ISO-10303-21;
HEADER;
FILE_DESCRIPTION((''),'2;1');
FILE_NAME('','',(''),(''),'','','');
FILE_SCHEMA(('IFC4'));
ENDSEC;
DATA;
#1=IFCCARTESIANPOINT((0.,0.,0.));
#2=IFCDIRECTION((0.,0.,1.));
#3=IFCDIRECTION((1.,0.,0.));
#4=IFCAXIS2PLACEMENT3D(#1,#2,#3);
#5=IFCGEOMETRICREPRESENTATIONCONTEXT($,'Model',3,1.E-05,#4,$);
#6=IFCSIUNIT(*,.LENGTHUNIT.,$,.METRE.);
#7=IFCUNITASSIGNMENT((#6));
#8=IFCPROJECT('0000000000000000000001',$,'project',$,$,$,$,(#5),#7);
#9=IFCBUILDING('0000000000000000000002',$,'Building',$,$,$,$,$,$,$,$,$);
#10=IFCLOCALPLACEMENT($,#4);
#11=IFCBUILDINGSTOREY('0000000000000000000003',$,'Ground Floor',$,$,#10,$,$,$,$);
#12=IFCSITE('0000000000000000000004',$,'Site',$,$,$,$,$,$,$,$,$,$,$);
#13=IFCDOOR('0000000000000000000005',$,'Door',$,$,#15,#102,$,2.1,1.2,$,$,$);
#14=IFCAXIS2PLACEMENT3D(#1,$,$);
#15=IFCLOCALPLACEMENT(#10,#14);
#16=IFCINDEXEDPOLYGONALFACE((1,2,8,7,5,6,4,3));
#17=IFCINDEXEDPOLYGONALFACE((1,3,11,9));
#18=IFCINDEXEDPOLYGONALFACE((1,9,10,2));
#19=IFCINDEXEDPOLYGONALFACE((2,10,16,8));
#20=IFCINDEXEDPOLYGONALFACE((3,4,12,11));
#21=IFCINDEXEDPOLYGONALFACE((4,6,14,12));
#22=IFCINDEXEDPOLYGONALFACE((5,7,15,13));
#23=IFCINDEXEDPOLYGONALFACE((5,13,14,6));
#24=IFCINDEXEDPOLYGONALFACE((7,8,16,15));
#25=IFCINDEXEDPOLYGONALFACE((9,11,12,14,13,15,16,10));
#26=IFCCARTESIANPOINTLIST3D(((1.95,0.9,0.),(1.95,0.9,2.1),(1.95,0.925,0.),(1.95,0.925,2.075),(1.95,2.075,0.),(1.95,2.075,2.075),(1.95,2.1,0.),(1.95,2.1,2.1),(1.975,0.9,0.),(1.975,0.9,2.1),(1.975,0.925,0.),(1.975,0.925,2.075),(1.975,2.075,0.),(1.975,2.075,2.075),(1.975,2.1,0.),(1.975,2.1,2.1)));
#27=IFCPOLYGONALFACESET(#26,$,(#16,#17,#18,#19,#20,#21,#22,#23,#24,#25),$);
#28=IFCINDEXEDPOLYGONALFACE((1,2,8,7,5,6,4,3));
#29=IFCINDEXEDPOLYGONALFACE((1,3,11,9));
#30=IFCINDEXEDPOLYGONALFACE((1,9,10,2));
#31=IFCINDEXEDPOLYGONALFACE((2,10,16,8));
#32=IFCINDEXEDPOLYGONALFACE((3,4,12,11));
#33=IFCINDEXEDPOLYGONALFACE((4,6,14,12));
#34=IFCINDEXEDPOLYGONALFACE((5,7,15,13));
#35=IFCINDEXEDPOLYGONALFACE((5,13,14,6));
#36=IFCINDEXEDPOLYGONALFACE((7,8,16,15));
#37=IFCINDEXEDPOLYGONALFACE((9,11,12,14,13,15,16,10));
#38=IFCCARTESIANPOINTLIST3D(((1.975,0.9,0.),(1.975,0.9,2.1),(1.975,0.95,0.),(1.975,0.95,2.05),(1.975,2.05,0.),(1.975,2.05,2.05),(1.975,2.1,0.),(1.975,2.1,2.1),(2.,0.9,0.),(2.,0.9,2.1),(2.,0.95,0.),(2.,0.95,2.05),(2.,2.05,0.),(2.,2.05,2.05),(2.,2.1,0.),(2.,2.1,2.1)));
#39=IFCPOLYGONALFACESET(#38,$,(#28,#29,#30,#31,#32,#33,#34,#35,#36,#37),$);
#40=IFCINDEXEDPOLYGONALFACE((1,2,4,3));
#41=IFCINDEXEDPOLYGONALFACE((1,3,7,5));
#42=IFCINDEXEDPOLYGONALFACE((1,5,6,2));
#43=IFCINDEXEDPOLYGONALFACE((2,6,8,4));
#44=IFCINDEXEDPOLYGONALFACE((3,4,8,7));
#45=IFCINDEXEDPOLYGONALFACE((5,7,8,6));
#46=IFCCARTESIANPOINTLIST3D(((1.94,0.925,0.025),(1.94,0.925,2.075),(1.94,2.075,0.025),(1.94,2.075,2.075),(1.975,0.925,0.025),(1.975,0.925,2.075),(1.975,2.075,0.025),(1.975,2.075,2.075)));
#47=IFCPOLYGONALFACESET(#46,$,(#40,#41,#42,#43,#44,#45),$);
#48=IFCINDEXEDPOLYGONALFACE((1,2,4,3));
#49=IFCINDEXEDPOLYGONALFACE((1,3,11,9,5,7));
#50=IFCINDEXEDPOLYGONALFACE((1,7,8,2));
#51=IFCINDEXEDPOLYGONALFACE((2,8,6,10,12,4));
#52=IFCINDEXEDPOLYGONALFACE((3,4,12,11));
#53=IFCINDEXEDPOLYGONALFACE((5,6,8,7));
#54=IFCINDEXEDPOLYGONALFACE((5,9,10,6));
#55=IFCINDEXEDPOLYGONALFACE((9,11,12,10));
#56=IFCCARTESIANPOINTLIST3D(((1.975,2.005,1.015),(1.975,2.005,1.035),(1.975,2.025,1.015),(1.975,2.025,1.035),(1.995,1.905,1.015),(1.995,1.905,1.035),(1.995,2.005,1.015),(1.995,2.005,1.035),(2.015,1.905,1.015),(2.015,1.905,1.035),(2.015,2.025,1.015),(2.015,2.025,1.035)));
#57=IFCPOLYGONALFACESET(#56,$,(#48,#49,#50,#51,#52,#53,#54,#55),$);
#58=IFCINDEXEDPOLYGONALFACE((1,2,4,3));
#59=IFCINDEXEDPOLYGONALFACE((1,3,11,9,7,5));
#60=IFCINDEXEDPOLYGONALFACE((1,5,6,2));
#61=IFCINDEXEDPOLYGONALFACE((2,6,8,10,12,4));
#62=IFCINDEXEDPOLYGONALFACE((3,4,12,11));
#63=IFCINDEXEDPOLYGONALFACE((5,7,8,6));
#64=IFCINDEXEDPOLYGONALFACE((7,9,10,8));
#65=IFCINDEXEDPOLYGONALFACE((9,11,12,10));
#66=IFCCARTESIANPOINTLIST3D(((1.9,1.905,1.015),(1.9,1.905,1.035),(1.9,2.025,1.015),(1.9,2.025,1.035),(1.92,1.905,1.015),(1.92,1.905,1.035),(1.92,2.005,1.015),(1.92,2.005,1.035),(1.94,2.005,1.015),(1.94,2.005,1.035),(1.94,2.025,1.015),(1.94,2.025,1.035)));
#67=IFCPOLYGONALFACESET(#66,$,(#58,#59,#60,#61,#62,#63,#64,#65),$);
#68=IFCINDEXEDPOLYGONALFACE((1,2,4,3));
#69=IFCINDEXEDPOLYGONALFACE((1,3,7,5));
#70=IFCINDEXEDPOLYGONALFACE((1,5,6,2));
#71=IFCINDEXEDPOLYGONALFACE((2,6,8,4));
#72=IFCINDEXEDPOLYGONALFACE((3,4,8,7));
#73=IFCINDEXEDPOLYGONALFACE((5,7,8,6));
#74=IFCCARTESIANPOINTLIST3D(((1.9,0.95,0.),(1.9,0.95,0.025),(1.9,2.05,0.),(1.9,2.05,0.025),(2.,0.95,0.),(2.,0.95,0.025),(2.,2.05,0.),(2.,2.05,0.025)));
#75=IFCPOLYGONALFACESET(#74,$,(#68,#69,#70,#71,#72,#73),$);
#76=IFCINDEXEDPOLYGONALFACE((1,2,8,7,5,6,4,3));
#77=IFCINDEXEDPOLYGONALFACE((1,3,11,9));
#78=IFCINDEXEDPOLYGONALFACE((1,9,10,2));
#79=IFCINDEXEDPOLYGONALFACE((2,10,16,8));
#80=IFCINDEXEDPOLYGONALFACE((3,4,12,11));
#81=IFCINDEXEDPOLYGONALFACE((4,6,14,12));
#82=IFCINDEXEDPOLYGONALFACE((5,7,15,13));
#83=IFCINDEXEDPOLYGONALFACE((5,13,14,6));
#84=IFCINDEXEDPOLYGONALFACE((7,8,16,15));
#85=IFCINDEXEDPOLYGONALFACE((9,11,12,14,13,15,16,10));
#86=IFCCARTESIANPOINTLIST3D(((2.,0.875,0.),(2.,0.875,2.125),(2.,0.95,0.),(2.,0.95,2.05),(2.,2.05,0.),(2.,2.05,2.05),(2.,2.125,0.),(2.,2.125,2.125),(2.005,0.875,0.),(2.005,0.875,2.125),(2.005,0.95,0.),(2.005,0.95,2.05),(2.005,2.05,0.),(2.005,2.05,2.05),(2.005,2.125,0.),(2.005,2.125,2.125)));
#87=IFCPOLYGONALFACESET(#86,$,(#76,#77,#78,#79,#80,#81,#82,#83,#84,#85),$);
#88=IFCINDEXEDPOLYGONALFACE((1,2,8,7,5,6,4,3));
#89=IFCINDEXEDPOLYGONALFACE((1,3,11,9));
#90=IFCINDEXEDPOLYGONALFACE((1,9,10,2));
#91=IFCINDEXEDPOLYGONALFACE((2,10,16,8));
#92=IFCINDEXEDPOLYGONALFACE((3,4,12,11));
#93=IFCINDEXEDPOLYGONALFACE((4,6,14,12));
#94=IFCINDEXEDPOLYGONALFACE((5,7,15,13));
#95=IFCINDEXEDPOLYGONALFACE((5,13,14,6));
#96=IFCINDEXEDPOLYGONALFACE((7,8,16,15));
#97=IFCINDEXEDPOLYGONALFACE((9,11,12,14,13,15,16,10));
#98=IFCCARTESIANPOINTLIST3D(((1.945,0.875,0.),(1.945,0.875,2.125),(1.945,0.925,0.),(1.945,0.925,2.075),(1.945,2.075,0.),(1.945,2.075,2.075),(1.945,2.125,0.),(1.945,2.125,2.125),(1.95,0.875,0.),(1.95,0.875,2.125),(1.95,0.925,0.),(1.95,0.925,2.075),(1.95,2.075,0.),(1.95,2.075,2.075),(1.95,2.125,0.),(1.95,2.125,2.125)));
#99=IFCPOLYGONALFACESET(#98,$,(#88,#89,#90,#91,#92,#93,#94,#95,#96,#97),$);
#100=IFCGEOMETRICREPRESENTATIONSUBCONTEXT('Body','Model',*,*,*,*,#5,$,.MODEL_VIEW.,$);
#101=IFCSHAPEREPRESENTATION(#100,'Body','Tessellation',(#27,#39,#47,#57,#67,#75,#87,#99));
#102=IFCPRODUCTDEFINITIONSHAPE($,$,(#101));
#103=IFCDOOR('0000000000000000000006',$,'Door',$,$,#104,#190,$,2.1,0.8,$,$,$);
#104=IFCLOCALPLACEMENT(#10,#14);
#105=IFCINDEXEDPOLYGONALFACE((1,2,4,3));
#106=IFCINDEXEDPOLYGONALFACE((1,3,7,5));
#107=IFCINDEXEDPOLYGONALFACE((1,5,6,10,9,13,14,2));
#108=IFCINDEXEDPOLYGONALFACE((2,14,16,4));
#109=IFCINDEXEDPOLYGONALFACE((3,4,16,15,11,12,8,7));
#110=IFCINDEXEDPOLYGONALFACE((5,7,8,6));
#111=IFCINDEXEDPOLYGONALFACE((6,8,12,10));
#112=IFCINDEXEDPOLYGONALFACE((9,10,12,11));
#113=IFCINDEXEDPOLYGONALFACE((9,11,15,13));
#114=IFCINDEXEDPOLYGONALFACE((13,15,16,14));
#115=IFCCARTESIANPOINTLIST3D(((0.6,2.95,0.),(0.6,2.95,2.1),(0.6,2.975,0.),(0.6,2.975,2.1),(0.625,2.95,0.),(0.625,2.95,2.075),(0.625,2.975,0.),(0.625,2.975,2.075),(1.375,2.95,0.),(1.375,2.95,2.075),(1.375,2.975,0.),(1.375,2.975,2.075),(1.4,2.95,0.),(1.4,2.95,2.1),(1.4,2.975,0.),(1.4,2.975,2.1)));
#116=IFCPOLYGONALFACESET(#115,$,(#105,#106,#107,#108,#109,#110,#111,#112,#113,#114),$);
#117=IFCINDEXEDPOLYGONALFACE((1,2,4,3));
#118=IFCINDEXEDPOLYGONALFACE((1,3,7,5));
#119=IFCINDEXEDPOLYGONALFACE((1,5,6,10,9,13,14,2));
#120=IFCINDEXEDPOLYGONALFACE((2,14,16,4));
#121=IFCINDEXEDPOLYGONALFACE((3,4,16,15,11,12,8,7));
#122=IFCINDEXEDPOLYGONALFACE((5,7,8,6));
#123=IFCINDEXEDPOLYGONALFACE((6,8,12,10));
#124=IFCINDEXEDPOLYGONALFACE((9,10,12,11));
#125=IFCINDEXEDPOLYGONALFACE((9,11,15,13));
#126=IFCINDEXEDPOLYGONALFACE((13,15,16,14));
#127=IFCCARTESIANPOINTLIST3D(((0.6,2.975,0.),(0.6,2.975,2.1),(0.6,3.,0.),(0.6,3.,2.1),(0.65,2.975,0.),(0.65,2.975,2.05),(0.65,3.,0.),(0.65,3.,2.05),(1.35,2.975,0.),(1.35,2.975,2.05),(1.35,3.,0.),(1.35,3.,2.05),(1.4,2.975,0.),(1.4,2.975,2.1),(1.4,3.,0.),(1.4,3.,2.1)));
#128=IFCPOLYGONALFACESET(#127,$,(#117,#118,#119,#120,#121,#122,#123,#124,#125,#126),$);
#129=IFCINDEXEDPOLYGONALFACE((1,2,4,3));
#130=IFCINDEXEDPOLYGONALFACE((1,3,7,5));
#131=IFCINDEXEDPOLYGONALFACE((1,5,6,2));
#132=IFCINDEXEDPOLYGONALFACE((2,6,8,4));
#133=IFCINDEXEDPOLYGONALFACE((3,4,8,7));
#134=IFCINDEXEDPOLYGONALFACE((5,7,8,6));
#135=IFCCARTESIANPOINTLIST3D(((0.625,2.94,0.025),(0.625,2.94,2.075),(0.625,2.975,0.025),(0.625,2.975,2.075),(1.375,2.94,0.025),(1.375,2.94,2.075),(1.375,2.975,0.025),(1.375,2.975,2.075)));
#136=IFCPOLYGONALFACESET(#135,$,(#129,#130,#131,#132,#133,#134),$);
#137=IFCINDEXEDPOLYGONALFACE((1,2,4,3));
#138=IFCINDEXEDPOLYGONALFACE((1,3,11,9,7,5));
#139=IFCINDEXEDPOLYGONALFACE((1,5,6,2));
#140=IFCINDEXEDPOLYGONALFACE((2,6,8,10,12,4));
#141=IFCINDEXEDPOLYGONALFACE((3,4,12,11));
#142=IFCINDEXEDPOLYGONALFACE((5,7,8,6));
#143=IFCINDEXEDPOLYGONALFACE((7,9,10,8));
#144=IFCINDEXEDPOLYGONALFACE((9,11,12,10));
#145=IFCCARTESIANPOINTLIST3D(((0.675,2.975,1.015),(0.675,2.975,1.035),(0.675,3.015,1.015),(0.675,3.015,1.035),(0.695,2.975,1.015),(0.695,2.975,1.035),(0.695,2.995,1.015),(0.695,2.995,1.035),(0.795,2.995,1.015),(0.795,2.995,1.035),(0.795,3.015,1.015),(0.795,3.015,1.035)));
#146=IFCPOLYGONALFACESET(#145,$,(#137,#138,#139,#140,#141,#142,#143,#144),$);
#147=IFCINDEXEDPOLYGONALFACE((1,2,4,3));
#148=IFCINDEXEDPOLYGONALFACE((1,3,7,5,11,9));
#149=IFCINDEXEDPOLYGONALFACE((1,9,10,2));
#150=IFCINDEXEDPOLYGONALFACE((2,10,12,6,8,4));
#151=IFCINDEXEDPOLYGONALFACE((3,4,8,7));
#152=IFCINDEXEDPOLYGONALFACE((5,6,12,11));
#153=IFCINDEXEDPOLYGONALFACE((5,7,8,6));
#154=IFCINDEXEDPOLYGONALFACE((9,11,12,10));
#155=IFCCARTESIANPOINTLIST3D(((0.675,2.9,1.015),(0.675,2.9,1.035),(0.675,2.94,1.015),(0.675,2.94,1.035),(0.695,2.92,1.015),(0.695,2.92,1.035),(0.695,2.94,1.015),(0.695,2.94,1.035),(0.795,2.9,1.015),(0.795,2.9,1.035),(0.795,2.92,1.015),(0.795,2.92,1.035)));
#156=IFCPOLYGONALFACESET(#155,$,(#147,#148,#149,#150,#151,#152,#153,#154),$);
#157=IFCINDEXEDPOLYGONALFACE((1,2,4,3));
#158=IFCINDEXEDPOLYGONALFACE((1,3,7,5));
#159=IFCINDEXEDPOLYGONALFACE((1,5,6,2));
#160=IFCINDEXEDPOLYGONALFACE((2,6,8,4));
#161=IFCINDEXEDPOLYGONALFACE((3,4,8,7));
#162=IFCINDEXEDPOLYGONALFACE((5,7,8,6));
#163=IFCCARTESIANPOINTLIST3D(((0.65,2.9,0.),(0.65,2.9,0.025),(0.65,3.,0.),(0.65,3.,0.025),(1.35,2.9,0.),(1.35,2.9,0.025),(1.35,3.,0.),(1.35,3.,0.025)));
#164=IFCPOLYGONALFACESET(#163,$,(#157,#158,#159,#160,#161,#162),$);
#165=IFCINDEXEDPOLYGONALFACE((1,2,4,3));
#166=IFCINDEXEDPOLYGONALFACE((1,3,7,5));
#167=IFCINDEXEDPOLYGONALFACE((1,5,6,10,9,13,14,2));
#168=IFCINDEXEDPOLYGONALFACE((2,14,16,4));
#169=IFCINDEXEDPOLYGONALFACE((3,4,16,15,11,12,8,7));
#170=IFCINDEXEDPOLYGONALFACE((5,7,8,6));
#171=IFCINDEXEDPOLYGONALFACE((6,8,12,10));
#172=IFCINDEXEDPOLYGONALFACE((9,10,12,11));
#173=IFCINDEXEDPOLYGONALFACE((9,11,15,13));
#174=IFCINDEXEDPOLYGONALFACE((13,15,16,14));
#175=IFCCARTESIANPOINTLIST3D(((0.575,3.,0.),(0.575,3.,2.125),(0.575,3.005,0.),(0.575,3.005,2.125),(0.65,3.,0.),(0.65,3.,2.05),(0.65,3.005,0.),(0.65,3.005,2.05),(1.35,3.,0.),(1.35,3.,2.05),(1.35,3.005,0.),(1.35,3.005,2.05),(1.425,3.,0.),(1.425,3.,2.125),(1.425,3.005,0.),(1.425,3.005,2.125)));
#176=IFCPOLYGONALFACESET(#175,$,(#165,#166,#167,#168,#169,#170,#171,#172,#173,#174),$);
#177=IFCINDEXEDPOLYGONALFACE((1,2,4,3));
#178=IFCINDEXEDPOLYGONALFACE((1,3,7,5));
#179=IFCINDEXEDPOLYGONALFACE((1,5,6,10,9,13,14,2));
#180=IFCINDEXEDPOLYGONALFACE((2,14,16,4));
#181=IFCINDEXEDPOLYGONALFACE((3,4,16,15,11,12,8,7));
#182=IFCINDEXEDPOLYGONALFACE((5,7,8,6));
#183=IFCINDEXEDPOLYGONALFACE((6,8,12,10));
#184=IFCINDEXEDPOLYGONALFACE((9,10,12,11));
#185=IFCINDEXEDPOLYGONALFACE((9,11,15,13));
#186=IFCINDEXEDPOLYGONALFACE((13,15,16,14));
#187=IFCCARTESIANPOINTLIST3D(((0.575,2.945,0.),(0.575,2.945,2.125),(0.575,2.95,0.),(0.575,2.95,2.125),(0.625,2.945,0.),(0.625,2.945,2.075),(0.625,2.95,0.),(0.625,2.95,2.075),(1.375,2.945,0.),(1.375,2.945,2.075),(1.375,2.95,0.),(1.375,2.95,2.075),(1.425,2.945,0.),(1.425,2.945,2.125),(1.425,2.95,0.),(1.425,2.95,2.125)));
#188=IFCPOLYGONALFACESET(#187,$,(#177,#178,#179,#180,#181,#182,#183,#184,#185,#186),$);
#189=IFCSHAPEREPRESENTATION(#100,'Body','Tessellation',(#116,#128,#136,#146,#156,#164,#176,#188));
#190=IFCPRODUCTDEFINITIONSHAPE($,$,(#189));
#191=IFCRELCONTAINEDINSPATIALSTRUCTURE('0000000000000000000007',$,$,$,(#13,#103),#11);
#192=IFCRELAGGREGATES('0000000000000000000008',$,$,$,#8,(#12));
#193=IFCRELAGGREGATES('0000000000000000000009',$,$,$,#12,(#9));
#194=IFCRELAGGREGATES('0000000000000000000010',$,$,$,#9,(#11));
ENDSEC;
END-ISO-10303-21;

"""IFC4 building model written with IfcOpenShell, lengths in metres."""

from ifc_helpers import new_model, si_unit, frame, origin_with_axes, place, context, subcontext, project, spatial, line, indexed_curve, outline, extrude, element, save


model = new_model("IFC4")

# Units and contexts
model_context = context("Model", 3, precision=1e-05, world=origin_with_axes())
body_context = subcontext(model_context, "Body", "Model", "MODEL_VIEW")
ifc_project = project(units=[si_unit("LENGTHUNIT", "METRE")], contexts=[model_context])

# Site, building, storey
site = spatial("IfcSite", under=ifc_project, Name="Site")
building = spatial("IfcBuilding", under=site, Name="Building")
storey_placement = place(None, origin_with_axes())
storey = spatial("IfcBuildingStorey", under=building, at=storey_placement, Name="Ground Floor")

# Doors
door_1_placement = place(storey_placement, frame((2.0, 0.9, 0.0), z_axis=(0.0, 0.0, 1.0), x_axis=(0.0, 1.0, 0.0)))
element("IfcDoor", 1, at=door_1_placement, inside=storey, Name="Door", OverallHeight=2.1, OverallWidth=1.2, context=body_context, shape_type="SweptSolid", body=[
    extrude(outline(indexed_curve([(0.0, 0.0), (0.0, 2.1), (1.2, 2.1), (1.2, 0.0), (1.175, 0.0), (1.175, 2.075), (0.025, 2.075), (0.025, 0.0)], segments=[line(1, 2, 3, 4, 5, 6, 7, 8, 1)])), frame((0.0, 0.025, 0.0), z_axis=(0.0, -1.0, 0.0), x_axis=(1.0, 0.0, 0.0)), (0.0, 0.0, -1.0), 0.025),
    extrude(outline(indexed_curve([(0.0, 0.0), (0.0, 2.1), (1.2, 2.1), (1.2, 0.0), (1.15, 0.0), (1.15, 2.05), (0.05, 2.05), (0.05, 0.0)], segments=[line(1, 2, 3, 4, 5, 6, 7, 8, 1)])), frame((0.0, 0.0, 0.0), z_axis=(0.0, -1.0, 0.0), x_axis=(1.0, 0.0, 0.0)), (0.0, 0.0, -1.0), 0.025),
    extrude(outline(indexed_curve([(0.0, 0.0), (1.15, 0.0), (1.15, 0.035), (0.0, 0.035)], segments=[line(1, 2, 3, 4, 1)])), frame((0.025, 0.025, 0.025), z_axis=(0.0, 0.0, 1.0), x_axis=(1.0, 0.0, 0.0)), (0.0, 0.0, 1.0), 2.05),
    extrude(outline(indexed_curve([(0.0, 0.0), (0.0, -0.04), (-0.12, -0.04), (-0.12, -0.02), (-0.02, -0.02), (-0.02, 0.0)], segments=[line(1, 2, 3, 4, 5, 6, 1)])), frame((1.125, 0.025, 1.015), z_axis=(0.0, 0.0, 1.0), x_axis=(1.0, 0.0, 0.0)), (0.0, 0.0, 1.0), 0.02),
    extrude(outline(indexed_curve([(0.0, 0.0), (0.0, 0.04), (-0.12, 0.04), (-0.12, 0.02), (-0.02, 0.02), (-0.02, 0.0)], segments=[line(1, 2, 3, 4, 5, 6, 1)])), frame((1.125, 0.06, 1.015), z_axis=(0.0, 0.0, 1.0), x_axis=(1.0, 0.0, 0.0)), (0.0, 0.0, 1.0), 0.02),
    extrude(outline(indexed_curve([(0.0, 0.0), (1.1, 0.0), (1.1, 0.1), (0.0, 0.1)], segments=[line(1, 2, 3, 4, 1)])), frame((0.05, 0.0, 0.0), z_axis=(0.0, 0.0, 1.0), x_axis=(1.0, 0.0, 0.0)), (0.0, 0.0, 1.0), 0.025),
    extrude(outline(indexed_curve([(0.0, 0.0), (0.0, 2.125), (1.25, 2.125), (1.25, 0.0), (1.175, 0.0), (1.175, 2.05), (0.075, 2.05), (0.075, 0.0)], segments=[line(1, 2, 3, 4, 5, 6, 7, 8, 1)])), frame((-0.025, -0.005, 0.0), z_axis=(0.0, -1.0, 0.0), x_axis=(1.0, 0.0, 0.0)), (0.0, 0.0, -1.0), 0.005),
    extrude(outline(indexed_curve([(0.0, 0.0), (0.0, 2.125), (1.25, 2.125), (1.25, 0.0), (1.2, 0.0), (1.2, 2.075), (0.05, 2.075), (0.05, 0.0)], segments=[line(1, 2, 3, 4, 5, 6, 7, 8, 1)])), frame((-0.025, 0.05, 0.0), z_axis=(0.0, -1.0, 0.0), x_axis=(1.0, 0.0, 0.0)), (0.0, 0.0, -1.0), 0.005),
])
door_2_placement = place(storey_placement, frame((1.4, 3.0, 0.0), z_axis=(0.0, 0.0, 1.0), x_axis=(-1.0, 0.0, 0.0)))
element("IfcDoor", 2, at=door_2_placement, inside=storey, Name="Door", OverallHeight=2.1, OverallWidth=0.8, context=body_context, shape_type="SweptSolid", body=[
    extrude(outline(indexed_curve([(0.0, 0.0), (0.0, 2.1), (0.8, 2.1), (0.8, 0.0), (0.775, 0.0), (0.775, 2.075), (0.025, 2.075), (0.025, 0.0)], segments=[line(1, 2, 3, 4, 5, 6, 7, 8, 1)])), frame((0.0, 0.025, 0.0), z_axis=(0.0, -1.0, 0.0), x_axis=(1.0, 0.0, 0.0)), (0.0, 0.0, -1.0), 0.025),
    extrude(outline(indexed_curve([(0.0, 0.0), (0.0, 2.1), (0.8, 2.1), (0.8, 0.0), (0.75, 0.0), (0.75, 2.05), (0.05, 2.05), (0.05, 0.0)], segments=[line(1, 2, 3, 4, 5, 6, 7, 8, 1)])), frame((0.0, 0.0, 0.0), z_axis=(0.0, -1.0, 0.0), x_axis=(1.0, 0.0, 0.0)), (0.0, 0.0, -1.0), 0.025),
    extrude(outline(indexed_curve([(0.0, 0.0), (0.75, 0.0), (0.75, 0.035), (0.0, 0.035)], segments=[line(1, 2, 3, 4, 1)])), frame((0.025, 0.025, 0.025), z_axis=(0.0, 0.0, 1.0), x_axis=(1.0, 0.0, 0.0)), (0.0, 0.0, 1.0), 2.05),
    extrude(outline(indexed_curve([(0.0, 0.0), (0.0, -0.04), (-0.12, -0.04), (-0.12, -0.02), (-0.02, -0.02), (-0.02, 0.0)], segments=[line(1, 2, 3, 4, 5, 6, 1)])), frame((0.725, 0.025, 1.015), z_axis=(0.0, 0.0, 1.0), x_axis=(1.0, 0.0, 0.0)), (0.0, 0.0, 1.0), 0.02),
    extrude(outline(indexed_curve([(0.0, 0.0), (0.0, 0.04), (-0.12, 0.04), (-0.12, 0.02), (-0.02, 0.02), (-0.02, 0.0)], segments=[line(1, 2, 3, 4, 5, 6, 1)])), frame((0.725, 0.06, 1.015), z_axis=(0.0, 0.0, 1.0), x_axis=(1.0, 0.0, 0.0)), (0.0, 0.0, 1.0), 0.02),
    extrude(outline(indexed_curve([(0.0, 0.0), (0.7, 0.0), (0.7, 0.1), (0.0, 0.1)], segments=[line(1, 2, 3, 4, 1)])), frame((0.05, 0.0, 0.0), z_axis=(0.0, 0.0, 1.0), x_axis=(1.0, 0.0, 0.0)), (0.0, 0.0, 1.0), 0.025),
    extrude(outline(indexed_curve([(0.0, 0.0), (0.0, 2.125), (0.85, 2.125), (0.85, 0.0), (0.775, 0.0), (0.775, 2.05), (0.075, 2.05), (0.075, 0.0)], segments=[line(1, 2, 3, 4, 5, 6, 7, 8, 1)])), frame((-0.025, -0.005, 0.0), z_axis=(0.0, -1.0, 0.0), x_axis=(1.0, 0.0, 0.0)), (0.0, 0.0, -1.0), 0.005),
    extrude(outline(indexed_curve([(0.0, 0.0), (0.0, 2.125), (0.85, 2.125), (0.85, 0.0), (0.8, 0.0), (0.8, 2.075), (0.05, 2.075), (0.05, 0.0)], segments=[line(1, 2, 3, 4, 5, 6, 7, 8, 1)])), frame((-0.025, 0.05, 0.0), z_axis=(0.0, -1.0, 0.0), x_axis=(1.0, 0.0, 0.0)), (0.0, 0.0, -1.0), 0.005),
])

save(model, "model.ifc")
